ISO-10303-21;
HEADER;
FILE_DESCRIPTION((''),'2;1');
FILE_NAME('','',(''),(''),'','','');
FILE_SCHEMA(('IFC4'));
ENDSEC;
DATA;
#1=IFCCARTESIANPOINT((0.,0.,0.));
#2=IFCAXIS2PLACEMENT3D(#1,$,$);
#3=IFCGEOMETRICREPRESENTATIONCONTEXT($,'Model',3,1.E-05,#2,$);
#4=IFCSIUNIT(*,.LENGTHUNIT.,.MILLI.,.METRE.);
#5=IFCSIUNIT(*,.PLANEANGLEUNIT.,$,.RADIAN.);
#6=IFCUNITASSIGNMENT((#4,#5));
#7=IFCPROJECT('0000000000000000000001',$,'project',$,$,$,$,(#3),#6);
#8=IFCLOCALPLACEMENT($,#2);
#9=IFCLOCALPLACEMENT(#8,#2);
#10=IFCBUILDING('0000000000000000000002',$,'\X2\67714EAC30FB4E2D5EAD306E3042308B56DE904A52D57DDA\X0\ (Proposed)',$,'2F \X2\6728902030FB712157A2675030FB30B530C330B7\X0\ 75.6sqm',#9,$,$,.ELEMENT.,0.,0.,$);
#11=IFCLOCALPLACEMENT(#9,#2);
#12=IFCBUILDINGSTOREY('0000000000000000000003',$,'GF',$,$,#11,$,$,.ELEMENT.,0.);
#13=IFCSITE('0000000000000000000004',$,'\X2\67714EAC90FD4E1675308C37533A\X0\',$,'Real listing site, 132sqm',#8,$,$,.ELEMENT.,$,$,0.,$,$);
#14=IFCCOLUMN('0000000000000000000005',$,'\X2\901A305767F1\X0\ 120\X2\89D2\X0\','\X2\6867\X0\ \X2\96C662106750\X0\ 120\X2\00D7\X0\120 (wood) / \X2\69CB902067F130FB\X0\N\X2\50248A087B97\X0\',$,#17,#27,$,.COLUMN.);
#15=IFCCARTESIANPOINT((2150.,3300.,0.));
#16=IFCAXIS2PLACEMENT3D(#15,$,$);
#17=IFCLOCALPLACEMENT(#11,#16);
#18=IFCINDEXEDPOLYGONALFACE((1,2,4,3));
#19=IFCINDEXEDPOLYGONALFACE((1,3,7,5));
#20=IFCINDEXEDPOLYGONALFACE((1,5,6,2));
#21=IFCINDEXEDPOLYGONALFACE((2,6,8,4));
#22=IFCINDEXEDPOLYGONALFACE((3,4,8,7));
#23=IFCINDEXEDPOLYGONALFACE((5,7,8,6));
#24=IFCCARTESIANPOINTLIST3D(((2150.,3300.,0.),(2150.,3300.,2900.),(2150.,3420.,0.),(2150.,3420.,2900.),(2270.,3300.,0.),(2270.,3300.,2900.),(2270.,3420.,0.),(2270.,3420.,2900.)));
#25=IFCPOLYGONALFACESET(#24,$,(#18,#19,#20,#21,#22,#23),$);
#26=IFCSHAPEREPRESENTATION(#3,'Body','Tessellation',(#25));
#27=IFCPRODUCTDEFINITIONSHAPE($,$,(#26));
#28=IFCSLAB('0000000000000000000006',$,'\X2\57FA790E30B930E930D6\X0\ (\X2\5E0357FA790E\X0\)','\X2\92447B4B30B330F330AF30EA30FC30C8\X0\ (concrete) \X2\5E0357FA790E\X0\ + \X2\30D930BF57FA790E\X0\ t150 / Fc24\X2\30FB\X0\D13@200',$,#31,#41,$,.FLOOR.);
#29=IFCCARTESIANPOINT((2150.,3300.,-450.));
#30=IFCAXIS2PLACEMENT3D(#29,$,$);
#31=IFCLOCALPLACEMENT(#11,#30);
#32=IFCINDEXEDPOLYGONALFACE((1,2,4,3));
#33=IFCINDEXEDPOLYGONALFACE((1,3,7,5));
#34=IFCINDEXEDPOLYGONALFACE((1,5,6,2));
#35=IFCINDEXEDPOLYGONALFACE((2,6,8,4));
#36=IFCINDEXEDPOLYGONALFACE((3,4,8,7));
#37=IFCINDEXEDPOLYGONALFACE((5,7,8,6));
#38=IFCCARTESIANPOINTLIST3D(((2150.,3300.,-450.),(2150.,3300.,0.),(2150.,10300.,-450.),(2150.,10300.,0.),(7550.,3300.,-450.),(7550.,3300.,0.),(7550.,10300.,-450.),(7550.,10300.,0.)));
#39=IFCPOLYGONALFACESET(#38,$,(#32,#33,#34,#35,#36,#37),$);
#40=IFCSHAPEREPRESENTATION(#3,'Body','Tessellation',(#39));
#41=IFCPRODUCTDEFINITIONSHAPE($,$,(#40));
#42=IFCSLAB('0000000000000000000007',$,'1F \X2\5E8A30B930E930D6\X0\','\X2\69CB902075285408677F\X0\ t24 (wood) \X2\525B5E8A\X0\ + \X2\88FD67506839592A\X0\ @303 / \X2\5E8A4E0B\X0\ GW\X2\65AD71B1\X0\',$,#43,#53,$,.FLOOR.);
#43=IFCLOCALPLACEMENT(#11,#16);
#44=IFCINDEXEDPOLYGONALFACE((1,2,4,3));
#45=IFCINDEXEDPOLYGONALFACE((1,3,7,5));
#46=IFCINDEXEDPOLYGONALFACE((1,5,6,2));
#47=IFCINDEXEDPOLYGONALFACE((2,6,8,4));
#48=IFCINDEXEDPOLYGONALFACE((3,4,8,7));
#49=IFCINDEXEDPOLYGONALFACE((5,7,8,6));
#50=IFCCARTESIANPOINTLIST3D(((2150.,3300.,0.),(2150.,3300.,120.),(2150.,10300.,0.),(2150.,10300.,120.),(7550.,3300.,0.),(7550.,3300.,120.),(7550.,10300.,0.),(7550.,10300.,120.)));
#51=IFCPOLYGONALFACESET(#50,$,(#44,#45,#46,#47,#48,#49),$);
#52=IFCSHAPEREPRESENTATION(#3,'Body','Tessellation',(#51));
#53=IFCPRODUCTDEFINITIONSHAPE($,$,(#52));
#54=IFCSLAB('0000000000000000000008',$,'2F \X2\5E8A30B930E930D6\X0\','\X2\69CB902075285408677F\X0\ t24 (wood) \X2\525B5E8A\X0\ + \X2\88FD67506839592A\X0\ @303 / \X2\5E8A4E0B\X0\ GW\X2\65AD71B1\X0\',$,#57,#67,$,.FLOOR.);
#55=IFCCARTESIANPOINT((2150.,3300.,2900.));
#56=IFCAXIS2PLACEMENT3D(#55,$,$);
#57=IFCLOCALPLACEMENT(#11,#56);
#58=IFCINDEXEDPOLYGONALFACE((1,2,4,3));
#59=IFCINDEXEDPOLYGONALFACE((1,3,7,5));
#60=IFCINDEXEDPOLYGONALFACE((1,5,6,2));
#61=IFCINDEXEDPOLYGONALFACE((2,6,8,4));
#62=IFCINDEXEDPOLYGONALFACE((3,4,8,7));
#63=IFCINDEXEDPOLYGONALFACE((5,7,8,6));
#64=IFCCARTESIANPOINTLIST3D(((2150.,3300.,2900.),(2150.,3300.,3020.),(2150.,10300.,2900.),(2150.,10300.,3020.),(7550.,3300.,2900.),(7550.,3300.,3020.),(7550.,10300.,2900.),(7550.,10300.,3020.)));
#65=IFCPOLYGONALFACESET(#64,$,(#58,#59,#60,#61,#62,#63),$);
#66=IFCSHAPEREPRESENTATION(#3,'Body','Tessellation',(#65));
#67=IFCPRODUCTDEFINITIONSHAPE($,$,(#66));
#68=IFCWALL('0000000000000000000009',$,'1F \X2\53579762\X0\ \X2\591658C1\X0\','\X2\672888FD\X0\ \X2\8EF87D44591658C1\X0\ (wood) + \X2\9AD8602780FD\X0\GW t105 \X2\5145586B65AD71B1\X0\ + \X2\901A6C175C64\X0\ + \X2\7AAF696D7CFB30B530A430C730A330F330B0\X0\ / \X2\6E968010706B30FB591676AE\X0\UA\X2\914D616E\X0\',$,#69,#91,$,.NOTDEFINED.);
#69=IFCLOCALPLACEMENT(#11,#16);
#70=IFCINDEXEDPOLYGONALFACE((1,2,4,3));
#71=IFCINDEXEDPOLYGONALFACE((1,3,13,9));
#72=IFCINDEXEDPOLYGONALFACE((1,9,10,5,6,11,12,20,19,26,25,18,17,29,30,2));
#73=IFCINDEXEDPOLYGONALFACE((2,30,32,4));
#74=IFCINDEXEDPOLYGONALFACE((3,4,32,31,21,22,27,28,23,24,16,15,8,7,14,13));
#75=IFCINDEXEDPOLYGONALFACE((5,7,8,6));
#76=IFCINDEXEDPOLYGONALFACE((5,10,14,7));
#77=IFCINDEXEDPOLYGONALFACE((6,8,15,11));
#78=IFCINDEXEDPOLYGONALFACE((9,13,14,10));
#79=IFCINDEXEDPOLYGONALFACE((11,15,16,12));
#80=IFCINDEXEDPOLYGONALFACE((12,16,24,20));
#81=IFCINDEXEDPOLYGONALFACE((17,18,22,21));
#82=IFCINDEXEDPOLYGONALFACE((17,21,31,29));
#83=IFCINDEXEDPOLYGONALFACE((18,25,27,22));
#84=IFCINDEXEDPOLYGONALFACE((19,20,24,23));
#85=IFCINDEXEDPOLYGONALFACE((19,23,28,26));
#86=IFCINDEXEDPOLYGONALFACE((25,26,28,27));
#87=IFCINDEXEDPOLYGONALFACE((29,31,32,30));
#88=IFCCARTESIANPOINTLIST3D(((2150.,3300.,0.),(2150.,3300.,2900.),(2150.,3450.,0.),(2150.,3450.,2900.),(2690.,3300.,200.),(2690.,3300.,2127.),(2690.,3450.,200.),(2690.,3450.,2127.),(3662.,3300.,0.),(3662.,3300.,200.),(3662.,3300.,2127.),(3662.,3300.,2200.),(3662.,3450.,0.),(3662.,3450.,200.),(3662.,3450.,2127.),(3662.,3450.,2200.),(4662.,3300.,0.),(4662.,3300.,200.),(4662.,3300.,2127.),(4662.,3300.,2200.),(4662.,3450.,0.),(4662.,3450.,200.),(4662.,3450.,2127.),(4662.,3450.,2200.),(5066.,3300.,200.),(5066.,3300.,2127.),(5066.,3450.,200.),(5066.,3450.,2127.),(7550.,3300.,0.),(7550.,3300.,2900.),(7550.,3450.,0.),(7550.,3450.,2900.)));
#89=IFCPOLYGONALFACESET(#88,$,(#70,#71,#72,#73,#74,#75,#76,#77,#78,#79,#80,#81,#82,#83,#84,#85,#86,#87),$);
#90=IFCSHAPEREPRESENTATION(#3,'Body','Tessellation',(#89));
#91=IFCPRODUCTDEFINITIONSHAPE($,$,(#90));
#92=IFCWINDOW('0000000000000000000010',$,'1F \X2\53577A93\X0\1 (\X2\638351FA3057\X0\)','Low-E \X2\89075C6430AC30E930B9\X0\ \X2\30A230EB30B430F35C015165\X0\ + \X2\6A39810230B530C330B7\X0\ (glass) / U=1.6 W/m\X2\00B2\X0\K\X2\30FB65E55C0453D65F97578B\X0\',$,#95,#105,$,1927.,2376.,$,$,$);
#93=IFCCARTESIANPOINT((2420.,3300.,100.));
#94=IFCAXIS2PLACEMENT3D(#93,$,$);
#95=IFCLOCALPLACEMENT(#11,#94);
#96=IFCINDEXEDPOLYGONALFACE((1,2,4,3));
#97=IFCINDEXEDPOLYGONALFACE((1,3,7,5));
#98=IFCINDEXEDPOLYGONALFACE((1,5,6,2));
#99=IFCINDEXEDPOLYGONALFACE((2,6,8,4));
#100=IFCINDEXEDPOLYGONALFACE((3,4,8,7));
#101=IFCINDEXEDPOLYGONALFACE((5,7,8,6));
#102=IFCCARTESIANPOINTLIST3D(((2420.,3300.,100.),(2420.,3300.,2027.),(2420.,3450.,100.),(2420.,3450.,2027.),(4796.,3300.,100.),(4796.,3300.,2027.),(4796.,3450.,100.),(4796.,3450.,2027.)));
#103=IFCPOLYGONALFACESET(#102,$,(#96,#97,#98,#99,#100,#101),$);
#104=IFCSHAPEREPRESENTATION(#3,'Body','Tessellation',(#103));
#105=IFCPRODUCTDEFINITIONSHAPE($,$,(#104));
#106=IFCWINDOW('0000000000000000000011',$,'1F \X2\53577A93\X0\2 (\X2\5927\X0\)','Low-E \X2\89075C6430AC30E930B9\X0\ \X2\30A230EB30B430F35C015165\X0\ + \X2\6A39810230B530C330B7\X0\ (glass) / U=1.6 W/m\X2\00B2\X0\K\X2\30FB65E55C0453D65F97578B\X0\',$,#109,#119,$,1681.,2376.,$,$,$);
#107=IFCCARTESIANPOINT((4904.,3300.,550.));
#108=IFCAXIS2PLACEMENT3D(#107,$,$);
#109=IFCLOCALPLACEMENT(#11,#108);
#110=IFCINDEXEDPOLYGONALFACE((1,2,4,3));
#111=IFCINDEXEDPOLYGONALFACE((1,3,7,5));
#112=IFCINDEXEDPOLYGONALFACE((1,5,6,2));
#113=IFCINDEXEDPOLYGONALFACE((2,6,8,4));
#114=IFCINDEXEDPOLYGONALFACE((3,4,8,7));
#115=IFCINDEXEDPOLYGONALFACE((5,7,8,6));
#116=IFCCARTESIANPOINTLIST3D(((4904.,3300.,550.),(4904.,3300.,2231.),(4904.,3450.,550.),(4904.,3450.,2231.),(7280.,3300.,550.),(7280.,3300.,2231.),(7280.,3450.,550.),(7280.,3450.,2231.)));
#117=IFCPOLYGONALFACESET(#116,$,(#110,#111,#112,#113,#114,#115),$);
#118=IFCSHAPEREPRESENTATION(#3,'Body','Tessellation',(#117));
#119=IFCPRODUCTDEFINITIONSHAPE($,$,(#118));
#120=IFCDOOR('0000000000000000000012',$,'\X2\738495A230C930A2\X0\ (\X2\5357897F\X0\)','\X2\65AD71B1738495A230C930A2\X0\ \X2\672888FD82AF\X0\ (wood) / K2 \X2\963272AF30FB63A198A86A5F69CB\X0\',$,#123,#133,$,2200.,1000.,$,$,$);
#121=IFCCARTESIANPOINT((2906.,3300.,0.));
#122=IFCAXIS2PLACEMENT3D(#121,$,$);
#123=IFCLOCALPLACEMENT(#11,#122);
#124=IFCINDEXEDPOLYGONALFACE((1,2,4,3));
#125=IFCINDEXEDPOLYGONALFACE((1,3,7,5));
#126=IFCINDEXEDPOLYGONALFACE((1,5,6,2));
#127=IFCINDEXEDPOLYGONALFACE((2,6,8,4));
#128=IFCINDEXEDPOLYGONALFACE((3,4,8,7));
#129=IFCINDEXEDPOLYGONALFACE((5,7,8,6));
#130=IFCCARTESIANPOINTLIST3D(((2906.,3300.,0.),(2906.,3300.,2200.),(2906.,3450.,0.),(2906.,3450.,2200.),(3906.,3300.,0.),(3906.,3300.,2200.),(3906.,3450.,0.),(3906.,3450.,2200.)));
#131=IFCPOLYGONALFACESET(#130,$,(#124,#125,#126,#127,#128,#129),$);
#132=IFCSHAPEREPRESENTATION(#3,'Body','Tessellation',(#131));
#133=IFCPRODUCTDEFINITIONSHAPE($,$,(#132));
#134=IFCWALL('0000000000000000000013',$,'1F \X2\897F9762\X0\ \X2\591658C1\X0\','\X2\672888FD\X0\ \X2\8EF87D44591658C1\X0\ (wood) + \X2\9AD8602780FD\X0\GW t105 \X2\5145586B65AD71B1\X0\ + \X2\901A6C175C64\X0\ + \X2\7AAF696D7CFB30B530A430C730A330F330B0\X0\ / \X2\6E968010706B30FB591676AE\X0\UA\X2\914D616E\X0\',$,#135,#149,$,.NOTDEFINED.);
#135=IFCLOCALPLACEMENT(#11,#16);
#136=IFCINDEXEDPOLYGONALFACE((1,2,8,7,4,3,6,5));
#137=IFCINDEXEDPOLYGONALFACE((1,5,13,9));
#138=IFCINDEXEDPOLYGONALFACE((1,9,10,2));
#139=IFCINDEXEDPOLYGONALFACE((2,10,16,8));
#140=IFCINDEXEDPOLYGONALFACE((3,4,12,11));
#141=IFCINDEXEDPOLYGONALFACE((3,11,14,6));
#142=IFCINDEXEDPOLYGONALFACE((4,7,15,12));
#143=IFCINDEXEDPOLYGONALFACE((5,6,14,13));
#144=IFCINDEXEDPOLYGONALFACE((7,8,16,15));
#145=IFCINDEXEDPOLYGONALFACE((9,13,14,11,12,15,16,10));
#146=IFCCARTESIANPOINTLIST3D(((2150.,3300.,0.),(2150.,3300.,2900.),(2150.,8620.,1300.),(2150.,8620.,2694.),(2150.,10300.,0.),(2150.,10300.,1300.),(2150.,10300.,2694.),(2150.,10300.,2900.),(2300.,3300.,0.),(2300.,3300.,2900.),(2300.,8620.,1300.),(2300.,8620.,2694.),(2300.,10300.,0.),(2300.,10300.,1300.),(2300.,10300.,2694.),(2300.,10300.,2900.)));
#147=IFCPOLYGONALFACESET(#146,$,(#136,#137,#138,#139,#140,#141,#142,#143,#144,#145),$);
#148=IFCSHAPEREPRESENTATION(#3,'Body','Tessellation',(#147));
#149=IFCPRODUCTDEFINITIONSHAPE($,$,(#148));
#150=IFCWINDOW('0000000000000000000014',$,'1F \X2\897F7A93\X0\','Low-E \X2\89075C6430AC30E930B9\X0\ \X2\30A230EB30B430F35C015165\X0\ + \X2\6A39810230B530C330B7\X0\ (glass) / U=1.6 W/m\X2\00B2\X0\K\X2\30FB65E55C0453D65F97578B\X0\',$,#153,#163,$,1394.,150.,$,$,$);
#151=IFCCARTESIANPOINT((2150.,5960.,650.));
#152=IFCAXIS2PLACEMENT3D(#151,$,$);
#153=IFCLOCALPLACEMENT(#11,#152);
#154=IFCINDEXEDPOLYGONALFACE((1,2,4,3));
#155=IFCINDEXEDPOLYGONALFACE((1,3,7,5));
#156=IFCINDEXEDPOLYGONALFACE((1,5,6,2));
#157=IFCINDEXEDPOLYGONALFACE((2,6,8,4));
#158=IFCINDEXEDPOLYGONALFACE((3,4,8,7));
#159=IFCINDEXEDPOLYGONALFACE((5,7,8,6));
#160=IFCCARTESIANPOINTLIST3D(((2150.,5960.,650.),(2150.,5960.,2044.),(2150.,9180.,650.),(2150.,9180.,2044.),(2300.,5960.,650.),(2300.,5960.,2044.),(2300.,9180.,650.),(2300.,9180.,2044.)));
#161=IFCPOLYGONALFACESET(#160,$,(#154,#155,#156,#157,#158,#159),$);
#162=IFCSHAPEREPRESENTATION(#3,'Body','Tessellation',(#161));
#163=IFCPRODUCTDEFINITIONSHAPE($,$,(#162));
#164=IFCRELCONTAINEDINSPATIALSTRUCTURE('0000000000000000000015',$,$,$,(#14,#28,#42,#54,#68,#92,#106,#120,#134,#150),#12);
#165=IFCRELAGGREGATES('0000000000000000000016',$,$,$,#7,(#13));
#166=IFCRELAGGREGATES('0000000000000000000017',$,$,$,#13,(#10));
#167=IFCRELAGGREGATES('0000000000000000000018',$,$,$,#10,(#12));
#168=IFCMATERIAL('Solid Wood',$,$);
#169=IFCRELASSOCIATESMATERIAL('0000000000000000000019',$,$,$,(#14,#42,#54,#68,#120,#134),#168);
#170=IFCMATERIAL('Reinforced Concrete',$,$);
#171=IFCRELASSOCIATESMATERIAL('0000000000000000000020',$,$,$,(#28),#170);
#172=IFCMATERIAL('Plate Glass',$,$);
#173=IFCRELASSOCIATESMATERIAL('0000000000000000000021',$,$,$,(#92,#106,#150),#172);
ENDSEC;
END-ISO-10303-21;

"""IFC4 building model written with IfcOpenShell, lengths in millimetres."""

from ifc_helpers import new_model, si_unit, frame, frame_2d, origin, place, context, project, spatial, rectangle, extrude, material, element, fill, save


model = new_model("IFC4")

# Units and contexts
model_context = context("Model", 3, precision=1e-05, world=origin())
ifc_project = project(units=[si_unit("LENGTHUNIT", "METRE", prefix="MILLI"), si_unit("PLANEANGLEUNIT", "RADIAN")], contexts=[model_context])

# Site, building, storey
site_placement = place(None, origin())
site = spatial("IfcSite", under=ifc_project, at=site_placement, Name="東京都世田谷区", ObjectType="Real listing site, 132sqm", CompositionType="ELEMENT", RefElevation=0.0)
building_placement = place(site_placement, origin())
building = spatial("IfcBuilding", under=site, at=building_placement, Name="東京・中庭のある回遊動線 (Proposed)", ObjectType="2F 木造・無垢材・サッシ 75.6sqm", CompositionType="ELEMENT", ElevationOfRefHeight=0.0, ElevationOfTerrain=0.0)
storey_placement = place(building_placement, origin())
storey = spatial("IfcBuildingStorey", under=building, at=storey_placement, Name="GF", CompositionType="ELEMENT", Elevation=0.0)

# Column
ifc_material_1 = material(Name="Solid Wood")
column_placement = place(storey_placement, frame((2150.0, 3300.0, 0.0)))
element("IfcColumn", 1, at=column_placement, inside=storey, material=ifc_material_1, Name="通し柱 120角", Description="桧 集成材 120×120 (wood) / 構造柱・N値計算", PredefinedType="COLUMN", context=model_context, shape_type="SweptSolid", body=[
    extrude(rectangle(XDim=120.0, YDim=120.0, at=frame_2d((60.0, 60.0))), frame((2150.0, 3300.0, 0.0)), (0.0, 0.0, 1.0), 2900.0),
])

# Slabs
ifc_material_2 = material(Name="Reinforced Concrete")
slab_1_placement = place(storey_placement, frame((2150.0, 3300.0, -450.0)))
element("IfcSlab", 2, at=slab_1_placement, inside=storey, material=ifc_material_2, Name="基礎スラブ (布基礎)", Description="鉄筋コンクリート (concrete) 布基礎 + ベタ基礎 t150 / Fc24・D13@200", PredefinedType="FLOOR", context=model_context, shape_type="SweptSolid", body=[
    extrude(rectangle(XDim=5400.0, YDim=7000.0, at=frame_2d((2700.0, 3500.0))), frame((2150.0, 3300.0, -450.0)), (0.0, 0.0, 1.0), 450.0),
])
slab_2_placement = place(storey_placement, frame((2150.0, 3300.0, 0.0)))
element("IfcSlab", 3, at=slab_2_placement, inside=storey, material=ifc_material_1, Name="1F 床スラブ", Description="構造用合板 t24 (wood) 剛床 + 製材根太 @303 / 床下 GW断熱", PredefinedType="FLOOR", context=model_context, shape_type="SweptSolid", body=[
    extrude(rectangle(XDim=5400.0, YDim=7000.0, at=frame_2d((2700.0, 3500.0))), frame((2150.0, 3300.0, 0.0)), (0.0, 0.0, 1.0), 120.0),
])
slab_3_placement = place(storey_placement, frame((2150.0, 3300.0, 2900.0)))
element("IfcSlab", 4, at=slab_3_placement, inside=storey, material=ifc_material_1, Name="2F 床スラブ", Description="構造用合板 t24 (wood) 剛床 + 製材根太 @303 / 床下 GW断熱", PredefinedType="FLOOR", context=model_context, shape_type="SweptSolid", body=[
    extrude(rectangle(XDim=5400.0, YDim=7000.0, at=frame_2d((2700.0, 3500.0))), frame((2150.0, 3300.0, 2900.0)), (0.0, 0.0, 1.0), 120.0),
])

# Wall, openings, windows, door
wall_1_placement = place(storey_placement, frame((2150.0, 3300.0, 0.0)))
wall_1 = element("IfcWall", 5, at=wall_1_placement, inside=storey, material=ifc_material_1, Name="1F 南面 外壁", Description="木製 軸組外壁 (wood) + 高性能GW t105 充填断熱 + 通気層 + 窯業系サイディング / 準耐火・外皮UA配慮", PredefinedType="NOTDEFINED", context=model_context, shape_type="SweptSolid", body=[
    extrude(rectangle(XDim=5400.0, YDim=150.0, at=frame_2d((2700.0, 75.0))), frame((2150.0, 3300.0, 0.0)), (0.0, 0.0, 1.0), 2900.0),
])
opening_1_placement = place(storey_placement, frame((2420.0, 3300.0, 100.0)))
opening_1 = element("IfcOpeningElement", 6, at=opening_1_placement, cuts=wall_1, PredefinedType="NOTDEFINED", context=model_context, shape_type="SweptSolid", body=[
    extrude(rectangle(XDim=2376.0, YDim=150.0, at=frame_2d((1188.0, 75.0))), frame((2420.0, 3300.0, 100.0)), (0.0, 0.0, 1.0), 1927.0),
])
opening_2_placement = place(storey_placement, frame((4904.0, 3300.0, 550.0)))
opening_2 = element("IfcOpeningElement", 7, at=opening_2_placement, cuts=wall_1, PredefinedType="NOTDEFINED", context=model_context, shape_type="SweptSolid", body=[
    extrude(rectangle(XDim=2376.0, YDim=150.0, at=frame_2d((1188.0, 75.0))), frame((4904.0, 3300.0, 550.0)), (0.0, 0.0, 1.0), 1681.0),
])
opening_3_placement = place(storey_placement, frame((2906.0, 3300.0, 0.0)))
opening_3 = element("IfcOpeningElement", 8, at=opening_3_placement, cuts=wall_1, PredefinedType="NOTDEFINED", context=model_context, shape_type="SweptSolid", body=[
    extrude(rectangle(XDim=1000.0, YDim=150.0, at=frame_2d((500.0, 75.0))), frame((2906.0, 3300.0, 0.0)), (0.0, 0.0, 1.0), 2200.0),
])
ifc_material_3 = material(Name="Plate Glass")
window_1_placement = place(storey_placement, frame((2420.0, 3300.0, 100.0)))
window_1 = element("IfcWindow", 9, at=window_1_placement, inside=storey, material=ifc_material_3, Name="1F 南窓1 (掃出し)", Description="Low-E 複層ガラス アルゴン封入 + 樹脂サッシ (glass) / U=1.6 W/m²K・日射取得型", OverallHeight=1927.0, OverallWidth=2376.0, context=model_context, shape_type="SweptSolid", body=[
    extrude(rectangle(XDim=2376.0, YDim=150.0, at=frame_2d((1188.0, 75.0))), frame((2420.0, 3300.0, 100.0)), (0.0, 0.0, 1.0), 1927.0),
])
fill(opening_1, window_1)
window_2_placement = place(storey_placement, frame((4904.0, 3300.0, 550.0)))
window_2 = element("IfcWindow", 10, at=window_2_placement, inside=storey, material=ifc_material_3, Name="1F 南窓2 (大)", Description="Low-E 複層ガラス アルゴン封入 + 樹脂サッシ (glass) / U=1.6 W/m²K・日射取得型", OverallHeight=1681.0, OverallWidth=2376.0, context=model_context, shape_type="SweptSolid", body=[
    extrude(rectangle(XDim=2376.0, YDim=150.0, at=frame_2d((1188.0, 75.0))), frame((4904.0, 3300.0, 550.0)), (0.0, 0.0, 1.0), 1681.0),
])
fill(opening_2, window_2)
door_placement = place(storey_placement, frame((2906.0, 3300.0, 0.0)))
door = element("IfcDoor", 11, at=door_placement, inside=storey, material=ifc_material_1, Name="玄関ドア (南西)", Description="断熱玄関ドア 木製芯 (wood) / K2 防犯・採風機構", OverallHeight=2200.0, OverallWidth=1000.0, context=model_context, shape_type="SweptSolid", body=[
    extrude(rectangle(XDim=1000.0, YDim=150.0, at=frame_2d((500.0, 75.0))), frame((2906.0, 3300.0, 0.0)), (0.0, 0.0, 1.0), 2200.0),
])
fill(opening_3, door)

# Wall, opening, window
wall_2_placement = place(storey_placement, frame((2150.0, 3300.0, 0.0)))
wall_2 = element("IfcWall", 12, at=wall_2_placement, inside=storey, material=ifc_material_1, Name="1F 西面 外壁", Description="木製 軸組外壁 (wood) + 高性能GW t105 充填断熱 + 通気層 + 窯業系サイディング / 準耐火・外皮UA配慮", PredefinedType="NOTDEFINED", context=model_context, shape_type="SweptSolid", body=[
    extrude(rectangle(XDim=150.0, YDim=7000.0, at=frame_2d((75.0, 3500.0))), frame((2150.0, 3300.0, 0.0)), (0.0, 0.0, 1.0), 2900.0),
])
opening_4_placement = place(storey_placement, frame((2150.0, 5960.0, 650.0)))
opening_4 = element("IfcOpeningElement", 13, at=opening_4_placement, cuts=wall_2, PredefinedType="NOTDEFINED", context=model_context, shape_type="SweptSolid", body=[
    extrude(rectangle(XDim=150.0, YDim=3220.0, at=frame_2d((75.0, 1610.0))), frame((2150.0, 5960.0, 650.0)), (0.0, 0.0, 1.0), 1394.0),
])
window_3_placement = place(storey_placement, frame((2150.0, 5960.0, 650.0)))
window_3 = element("IfcWindow", 14, at=window_3_placement, inside=storey, material=ifc_material_3, Name="1F 西窓", Description="Low-E 複層ガラス アルゴン封入 + 樹脂サッシ (glass) / U=1.6 W/m²K・日射取得型", OverallHeight=1394.0, OverallWidth=150.0, context=model_context, shape_type="SweptSolid", body=[
    extrude(rectangle(XDim=150.0, YDim=3220.0, at=frame_2d((75.0, 1610.0))), frame((2150.0, 5960.0, 650.0)), (0.0, 0.0, 1.0), 1394.0),
])
fill(opening_4, window_3)

save(model, "model.ifc")
